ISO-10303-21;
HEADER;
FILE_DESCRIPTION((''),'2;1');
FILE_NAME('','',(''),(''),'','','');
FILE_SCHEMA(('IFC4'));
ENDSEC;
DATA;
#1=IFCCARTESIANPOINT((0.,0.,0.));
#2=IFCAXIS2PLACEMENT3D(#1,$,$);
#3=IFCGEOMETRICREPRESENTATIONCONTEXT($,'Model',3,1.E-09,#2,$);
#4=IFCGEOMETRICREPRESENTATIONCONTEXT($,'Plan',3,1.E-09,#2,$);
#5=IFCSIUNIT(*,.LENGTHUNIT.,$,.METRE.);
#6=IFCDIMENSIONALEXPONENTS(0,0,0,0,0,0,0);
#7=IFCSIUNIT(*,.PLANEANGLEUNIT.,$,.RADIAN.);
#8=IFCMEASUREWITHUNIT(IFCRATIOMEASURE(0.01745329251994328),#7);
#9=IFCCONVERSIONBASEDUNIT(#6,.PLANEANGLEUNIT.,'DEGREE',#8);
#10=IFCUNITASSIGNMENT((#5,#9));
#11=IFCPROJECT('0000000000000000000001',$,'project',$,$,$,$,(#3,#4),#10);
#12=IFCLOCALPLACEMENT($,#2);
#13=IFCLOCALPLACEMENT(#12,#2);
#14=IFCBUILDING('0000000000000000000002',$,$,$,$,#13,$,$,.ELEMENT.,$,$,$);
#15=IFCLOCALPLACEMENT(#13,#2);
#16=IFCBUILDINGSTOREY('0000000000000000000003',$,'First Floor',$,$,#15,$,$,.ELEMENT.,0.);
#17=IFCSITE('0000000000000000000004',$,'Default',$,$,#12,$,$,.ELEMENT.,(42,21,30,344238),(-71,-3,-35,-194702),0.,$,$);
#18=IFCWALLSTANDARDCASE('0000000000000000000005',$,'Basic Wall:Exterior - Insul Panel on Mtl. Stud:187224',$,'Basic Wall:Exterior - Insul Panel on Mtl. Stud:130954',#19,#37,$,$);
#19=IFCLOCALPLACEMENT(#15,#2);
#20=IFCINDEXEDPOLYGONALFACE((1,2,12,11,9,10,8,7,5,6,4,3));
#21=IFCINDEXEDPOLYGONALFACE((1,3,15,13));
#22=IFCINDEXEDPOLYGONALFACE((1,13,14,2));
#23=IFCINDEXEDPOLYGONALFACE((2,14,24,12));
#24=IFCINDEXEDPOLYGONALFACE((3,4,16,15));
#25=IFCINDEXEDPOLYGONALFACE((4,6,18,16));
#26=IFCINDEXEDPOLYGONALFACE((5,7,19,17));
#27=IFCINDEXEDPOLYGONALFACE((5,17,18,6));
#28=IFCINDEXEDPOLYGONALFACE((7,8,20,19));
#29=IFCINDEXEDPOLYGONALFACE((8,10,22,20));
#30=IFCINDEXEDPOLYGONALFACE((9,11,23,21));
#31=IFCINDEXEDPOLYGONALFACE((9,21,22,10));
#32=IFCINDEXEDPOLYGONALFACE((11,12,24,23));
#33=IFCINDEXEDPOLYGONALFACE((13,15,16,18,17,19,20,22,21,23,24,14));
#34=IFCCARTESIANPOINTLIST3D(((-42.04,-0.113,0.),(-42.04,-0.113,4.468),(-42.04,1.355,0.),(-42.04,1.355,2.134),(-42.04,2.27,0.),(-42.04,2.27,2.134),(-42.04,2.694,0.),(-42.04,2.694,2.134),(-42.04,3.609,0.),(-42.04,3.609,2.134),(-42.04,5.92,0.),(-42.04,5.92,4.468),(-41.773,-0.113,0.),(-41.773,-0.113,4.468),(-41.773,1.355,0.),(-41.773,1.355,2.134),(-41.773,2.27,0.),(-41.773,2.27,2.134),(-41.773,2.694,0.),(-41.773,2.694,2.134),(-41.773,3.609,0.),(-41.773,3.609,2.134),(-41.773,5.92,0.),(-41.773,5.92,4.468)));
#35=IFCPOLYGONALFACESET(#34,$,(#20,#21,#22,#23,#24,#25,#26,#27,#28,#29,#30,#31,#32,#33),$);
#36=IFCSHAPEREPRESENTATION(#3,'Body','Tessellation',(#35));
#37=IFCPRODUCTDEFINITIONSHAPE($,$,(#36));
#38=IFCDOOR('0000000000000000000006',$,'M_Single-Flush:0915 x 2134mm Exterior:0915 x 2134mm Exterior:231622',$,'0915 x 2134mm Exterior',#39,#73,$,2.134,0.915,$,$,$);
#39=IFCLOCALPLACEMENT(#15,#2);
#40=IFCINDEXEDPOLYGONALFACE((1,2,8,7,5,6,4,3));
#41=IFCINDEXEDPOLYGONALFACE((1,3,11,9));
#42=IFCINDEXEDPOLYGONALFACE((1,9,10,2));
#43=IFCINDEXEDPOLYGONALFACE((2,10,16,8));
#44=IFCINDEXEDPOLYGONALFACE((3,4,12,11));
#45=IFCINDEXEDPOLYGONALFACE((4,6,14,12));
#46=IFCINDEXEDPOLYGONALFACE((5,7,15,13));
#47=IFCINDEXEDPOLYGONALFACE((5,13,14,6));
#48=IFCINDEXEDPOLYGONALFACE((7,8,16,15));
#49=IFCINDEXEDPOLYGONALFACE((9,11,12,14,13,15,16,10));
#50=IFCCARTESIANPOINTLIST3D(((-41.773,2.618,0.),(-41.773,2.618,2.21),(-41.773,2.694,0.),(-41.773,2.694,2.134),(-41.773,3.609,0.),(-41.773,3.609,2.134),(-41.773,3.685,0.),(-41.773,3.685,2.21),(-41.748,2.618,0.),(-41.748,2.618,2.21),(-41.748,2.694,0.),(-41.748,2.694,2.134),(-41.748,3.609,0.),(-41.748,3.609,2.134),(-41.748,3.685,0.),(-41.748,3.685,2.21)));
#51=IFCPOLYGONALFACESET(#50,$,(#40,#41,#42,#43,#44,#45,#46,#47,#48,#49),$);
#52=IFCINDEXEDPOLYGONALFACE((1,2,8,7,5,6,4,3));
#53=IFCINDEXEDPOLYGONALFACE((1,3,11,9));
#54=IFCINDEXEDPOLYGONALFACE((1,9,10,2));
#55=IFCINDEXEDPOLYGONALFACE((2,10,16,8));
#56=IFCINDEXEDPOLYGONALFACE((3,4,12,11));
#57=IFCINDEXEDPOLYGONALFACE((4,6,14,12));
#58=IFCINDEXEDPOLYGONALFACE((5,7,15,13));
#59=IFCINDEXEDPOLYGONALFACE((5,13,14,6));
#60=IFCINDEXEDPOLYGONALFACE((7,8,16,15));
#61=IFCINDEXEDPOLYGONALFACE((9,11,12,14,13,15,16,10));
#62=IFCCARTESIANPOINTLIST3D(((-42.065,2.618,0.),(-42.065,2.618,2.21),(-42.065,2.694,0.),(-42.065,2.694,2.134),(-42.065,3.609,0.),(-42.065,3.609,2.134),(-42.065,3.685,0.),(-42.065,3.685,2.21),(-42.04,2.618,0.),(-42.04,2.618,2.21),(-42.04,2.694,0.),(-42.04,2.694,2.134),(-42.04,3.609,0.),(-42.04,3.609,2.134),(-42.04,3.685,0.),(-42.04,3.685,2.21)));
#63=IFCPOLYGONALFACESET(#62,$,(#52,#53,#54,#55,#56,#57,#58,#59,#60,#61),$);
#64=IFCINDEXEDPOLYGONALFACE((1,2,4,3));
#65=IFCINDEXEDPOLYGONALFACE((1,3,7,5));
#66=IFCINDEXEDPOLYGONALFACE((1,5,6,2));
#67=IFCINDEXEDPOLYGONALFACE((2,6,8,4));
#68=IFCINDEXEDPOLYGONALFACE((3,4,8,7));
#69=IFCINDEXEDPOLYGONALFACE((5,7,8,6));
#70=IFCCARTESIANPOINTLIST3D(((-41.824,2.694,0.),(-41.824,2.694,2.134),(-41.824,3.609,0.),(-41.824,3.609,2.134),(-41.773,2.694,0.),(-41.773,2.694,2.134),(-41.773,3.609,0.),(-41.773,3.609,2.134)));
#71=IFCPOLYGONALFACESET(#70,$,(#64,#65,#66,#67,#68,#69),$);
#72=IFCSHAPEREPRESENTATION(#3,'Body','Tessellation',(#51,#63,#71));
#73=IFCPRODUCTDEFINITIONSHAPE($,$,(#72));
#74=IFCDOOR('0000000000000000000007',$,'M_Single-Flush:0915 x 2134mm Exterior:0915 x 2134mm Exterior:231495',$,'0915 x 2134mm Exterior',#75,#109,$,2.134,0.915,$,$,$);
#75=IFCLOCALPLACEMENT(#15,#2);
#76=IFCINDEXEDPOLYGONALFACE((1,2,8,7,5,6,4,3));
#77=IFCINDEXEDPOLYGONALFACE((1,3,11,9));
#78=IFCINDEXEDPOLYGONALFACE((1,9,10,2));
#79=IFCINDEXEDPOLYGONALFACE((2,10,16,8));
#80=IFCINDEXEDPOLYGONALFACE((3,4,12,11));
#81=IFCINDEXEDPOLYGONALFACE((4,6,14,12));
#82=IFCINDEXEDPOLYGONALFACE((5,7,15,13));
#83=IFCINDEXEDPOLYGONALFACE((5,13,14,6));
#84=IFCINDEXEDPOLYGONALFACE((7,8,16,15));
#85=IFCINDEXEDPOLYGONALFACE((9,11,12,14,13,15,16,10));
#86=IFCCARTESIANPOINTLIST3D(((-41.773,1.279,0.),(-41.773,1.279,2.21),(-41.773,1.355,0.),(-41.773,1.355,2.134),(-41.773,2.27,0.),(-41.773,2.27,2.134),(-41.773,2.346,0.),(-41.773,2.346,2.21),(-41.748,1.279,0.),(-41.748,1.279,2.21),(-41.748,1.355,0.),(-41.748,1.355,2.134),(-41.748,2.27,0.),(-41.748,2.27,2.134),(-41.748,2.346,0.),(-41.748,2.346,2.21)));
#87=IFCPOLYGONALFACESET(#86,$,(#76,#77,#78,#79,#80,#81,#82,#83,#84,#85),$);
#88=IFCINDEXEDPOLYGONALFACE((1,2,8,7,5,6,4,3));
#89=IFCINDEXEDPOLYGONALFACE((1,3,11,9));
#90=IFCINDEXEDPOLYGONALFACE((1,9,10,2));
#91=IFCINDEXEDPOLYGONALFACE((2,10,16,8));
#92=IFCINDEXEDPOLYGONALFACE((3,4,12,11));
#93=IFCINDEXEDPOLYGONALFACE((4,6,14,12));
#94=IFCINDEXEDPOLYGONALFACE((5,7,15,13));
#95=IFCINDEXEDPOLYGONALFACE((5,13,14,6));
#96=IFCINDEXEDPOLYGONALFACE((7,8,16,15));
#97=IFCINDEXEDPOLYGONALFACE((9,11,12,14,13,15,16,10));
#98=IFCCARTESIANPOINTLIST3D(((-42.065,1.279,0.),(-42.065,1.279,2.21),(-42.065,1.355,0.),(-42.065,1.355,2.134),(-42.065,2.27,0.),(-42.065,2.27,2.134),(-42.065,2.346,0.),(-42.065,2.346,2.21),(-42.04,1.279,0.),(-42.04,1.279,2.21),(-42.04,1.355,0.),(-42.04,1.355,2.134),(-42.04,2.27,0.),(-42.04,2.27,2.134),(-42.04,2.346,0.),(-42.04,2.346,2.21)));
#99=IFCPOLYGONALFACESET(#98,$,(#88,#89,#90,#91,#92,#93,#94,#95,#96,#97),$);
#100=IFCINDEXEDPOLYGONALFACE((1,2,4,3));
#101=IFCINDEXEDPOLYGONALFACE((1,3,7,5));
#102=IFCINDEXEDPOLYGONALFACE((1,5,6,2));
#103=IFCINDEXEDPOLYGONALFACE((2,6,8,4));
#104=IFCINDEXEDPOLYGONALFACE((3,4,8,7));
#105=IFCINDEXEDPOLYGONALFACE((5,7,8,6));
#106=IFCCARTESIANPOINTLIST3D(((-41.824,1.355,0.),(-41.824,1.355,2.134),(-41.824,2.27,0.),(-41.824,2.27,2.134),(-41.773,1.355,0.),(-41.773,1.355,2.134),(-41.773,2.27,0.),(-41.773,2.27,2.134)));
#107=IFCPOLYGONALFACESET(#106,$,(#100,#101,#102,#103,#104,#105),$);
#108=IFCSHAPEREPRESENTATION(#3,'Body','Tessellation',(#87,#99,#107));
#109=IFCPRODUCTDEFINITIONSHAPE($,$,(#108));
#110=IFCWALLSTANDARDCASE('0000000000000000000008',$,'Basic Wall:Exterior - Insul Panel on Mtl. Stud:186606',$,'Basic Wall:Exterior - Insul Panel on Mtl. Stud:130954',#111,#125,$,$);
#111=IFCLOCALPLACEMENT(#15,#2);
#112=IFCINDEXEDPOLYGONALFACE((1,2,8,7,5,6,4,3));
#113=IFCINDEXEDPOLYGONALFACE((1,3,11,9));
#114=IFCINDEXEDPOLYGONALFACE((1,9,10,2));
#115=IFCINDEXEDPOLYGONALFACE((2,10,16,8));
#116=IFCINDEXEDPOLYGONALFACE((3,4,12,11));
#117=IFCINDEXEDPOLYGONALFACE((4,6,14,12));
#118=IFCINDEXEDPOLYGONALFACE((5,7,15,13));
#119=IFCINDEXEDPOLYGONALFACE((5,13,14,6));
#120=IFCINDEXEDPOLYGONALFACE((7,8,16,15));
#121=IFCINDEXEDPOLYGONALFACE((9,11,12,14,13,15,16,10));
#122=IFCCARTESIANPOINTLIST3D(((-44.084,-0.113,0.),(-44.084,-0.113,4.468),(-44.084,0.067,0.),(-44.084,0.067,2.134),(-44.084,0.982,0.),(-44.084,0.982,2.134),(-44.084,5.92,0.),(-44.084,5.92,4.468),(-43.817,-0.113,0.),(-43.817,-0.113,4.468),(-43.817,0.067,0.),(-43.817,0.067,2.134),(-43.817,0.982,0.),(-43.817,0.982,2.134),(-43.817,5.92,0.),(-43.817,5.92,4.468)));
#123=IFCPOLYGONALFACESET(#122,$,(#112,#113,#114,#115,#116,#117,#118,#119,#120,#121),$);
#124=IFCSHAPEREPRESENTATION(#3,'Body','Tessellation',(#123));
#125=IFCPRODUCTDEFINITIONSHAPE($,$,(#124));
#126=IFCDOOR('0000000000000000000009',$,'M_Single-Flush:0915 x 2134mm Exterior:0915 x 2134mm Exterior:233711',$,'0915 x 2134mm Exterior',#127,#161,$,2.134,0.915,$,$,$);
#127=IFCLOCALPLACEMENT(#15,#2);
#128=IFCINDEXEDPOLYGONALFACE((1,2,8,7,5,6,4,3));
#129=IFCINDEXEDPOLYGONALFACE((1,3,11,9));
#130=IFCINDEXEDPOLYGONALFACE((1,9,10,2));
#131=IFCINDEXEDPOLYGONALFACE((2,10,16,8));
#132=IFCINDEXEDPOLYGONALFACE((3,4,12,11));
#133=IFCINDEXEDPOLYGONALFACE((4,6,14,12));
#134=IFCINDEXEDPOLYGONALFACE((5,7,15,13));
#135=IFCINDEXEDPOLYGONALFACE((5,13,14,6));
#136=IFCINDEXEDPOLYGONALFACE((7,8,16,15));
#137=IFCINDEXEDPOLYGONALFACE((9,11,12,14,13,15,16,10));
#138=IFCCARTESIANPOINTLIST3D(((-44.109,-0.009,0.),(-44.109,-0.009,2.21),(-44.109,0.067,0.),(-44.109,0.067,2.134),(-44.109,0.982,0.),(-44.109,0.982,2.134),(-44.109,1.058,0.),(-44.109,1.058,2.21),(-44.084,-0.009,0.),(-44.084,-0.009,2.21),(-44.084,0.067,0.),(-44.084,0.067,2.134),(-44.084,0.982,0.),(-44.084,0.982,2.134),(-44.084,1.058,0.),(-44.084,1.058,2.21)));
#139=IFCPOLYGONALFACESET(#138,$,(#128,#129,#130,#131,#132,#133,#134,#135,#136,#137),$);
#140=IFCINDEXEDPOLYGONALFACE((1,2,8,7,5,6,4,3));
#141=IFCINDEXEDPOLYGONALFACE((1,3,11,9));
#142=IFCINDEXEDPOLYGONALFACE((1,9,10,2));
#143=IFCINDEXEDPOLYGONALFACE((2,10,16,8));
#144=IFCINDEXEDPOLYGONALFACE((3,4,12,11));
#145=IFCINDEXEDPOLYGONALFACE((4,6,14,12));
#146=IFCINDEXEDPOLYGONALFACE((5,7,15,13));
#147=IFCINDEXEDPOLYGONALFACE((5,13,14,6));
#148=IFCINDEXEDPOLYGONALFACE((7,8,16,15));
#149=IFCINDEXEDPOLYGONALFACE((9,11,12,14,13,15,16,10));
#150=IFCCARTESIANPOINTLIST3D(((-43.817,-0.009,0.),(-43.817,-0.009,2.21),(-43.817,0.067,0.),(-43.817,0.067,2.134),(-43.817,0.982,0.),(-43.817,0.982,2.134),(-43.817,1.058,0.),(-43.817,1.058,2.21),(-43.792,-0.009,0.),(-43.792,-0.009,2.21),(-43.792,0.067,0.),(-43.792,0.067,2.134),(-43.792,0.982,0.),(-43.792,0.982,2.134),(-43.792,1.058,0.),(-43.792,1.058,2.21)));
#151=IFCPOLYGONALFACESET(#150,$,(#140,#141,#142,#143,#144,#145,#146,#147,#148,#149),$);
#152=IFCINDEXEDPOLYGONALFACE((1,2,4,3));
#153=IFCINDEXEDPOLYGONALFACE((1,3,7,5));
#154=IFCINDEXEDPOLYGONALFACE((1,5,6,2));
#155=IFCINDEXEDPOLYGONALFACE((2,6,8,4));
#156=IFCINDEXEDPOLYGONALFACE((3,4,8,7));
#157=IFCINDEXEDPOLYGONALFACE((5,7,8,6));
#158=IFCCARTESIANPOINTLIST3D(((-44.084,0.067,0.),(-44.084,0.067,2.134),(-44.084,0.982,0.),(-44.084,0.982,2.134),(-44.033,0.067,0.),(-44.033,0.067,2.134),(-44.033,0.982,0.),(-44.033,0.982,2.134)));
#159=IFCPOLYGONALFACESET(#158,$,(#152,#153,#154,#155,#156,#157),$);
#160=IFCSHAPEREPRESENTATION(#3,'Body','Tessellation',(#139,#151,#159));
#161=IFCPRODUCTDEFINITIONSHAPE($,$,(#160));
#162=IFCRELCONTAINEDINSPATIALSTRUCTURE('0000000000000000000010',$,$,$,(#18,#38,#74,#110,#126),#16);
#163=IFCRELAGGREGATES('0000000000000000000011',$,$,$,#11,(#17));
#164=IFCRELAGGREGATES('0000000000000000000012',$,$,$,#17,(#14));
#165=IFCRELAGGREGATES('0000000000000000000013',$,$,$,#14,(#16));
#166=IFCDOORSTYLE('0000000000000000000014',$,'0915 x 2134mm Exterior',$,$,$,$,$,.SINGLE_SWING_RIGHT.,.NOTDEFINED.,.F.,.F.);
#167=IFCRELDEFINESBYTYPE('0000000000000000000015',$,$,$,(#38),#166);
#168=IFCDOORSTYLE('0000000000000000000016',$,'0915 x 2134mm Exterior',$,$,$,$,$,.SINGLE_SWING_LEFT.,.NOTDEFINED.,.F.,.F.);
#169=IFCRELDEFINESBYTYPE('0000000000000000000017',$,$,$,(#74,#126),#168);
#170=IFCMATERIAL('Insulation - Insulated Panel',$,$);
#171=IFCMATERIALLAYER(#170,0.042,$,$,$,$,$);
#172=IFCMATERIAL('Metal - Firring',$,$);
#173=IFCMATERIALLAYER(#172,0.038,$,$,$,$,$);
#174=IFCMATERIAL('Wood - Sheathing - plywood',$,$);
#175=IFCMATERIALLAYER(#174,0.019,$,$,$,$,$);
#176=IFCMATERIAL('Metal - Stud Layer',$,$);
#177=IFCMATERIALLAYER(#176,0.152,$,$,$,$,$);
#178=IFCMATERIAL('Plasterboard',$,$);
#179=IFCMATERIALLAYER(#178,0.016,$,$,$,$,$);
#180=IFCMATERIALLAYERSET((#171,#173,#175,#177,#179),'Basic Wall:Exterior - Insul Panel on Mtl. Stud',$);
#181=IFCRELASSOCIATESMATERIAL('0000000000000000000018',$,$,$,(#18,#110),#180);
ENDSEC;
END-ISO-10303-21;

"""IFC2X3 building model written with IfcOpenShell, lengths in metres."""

from ifc_helpers import new_model, entity, si_unit, converted_unit, frame, frame_2d, origin, origin_2d_with_axis, place, context, project, spatial, polyline, rectangle, outline, extrude, source, transform, mapped, material, layer, layer_set, layer_usage, type_object, type_shapes, element, fill, save


model = new_model("IFC2X3")

# Units and contexts
model_context = context("Model", 3, precision=1e-09, world=origin())
plan_context = context("Plan", 3, precision=1e-09, world=origin())
ifc_project = project(units=[si_unit("LENGTHUNIT", "METRE"), converted_unit("PLANEANGLEUNIT", "DEGREE", entity("IfcRatioMeasure", 0.01745329251994328), si_unit("PLANEANGLEUNIT", "RADIAN"), dimensions=[0, 0, 0, 0, 0, 0, 0])], contexts=[model_context, plan_context])

# Site, building, storey
site_placement = place(None, origin())
site = spatial("IfcSite", under=ifc_project, at=site_placement, Name="Default", CompositionType="ELEMENT", RefLatitude=(42, 21, 30, 344238), RefLongitude=(-71, -3, -35, -194702), RefElevation=0.0)
building_placement = place(site_placement, origin())
building = spatial("IfcBuilding", under=site, at=building_placement, CompositionType="ELEMENT")
storey_placement = place(building_placement, origin())
storey = spatial("IfcBuildingStorey", under=building, at=storey_placement, Name="First Floor", CompositionType="ELEMENT", Elevation=0.0)

# Shared definitions
ifc_material_1 = material(Name="Plasterboard")
ifc_material_2 = material(Name="Metal - Stud Layer")

# Wall, openings, doors
ifc_material_3 = material(Name="Insulation - Insulated Panel")
ifc_layer_1 = layer(ifc_material_3, 0.042)
ifc_material_4 = material(Name="Metal - Firring")
ifc_layer_2 = layer(ifc_material_4, 0.038)
ifc_material_5 = material(Name="Wood - Sheathing - plywood")
ifc_layer_3 = layer(ifc_material_5, 0.019)
ifc_layer_4 = layer(ifc_material_2, 0.152)
ifc_layer_5 = layer(ifc_material_1, 0.016)
ifc_layer_set_1 = layer_set([ifc_layer_1, ifc_layer_2, ifc_layer_3, ifc_layer_4, ifc_layer_5], Name="Basic Wall:Exterior - Insul Panel on Mtl. Stud")
ifc_layer_usage_1 = layer_usage(ifc_layer_set_1, "AXIS2", "NEGATIVE", 0.1335)
wall_1_placement = place(storey_placement, frame((-41.9065, -0.113, 0.0), z_axis=(0.0, 0.0, 1.0), x_axis=(0.0, 1.0, 0.0)))
wall_1 = element("IfcWallStandardCase", 1, at=wall_1_placement, inside=storey, material=ifc_layer_usage_1, Name="Basic Wall:Exterior - Insul Panel on Mtl. Stud:187224", ObjectType="Basic Wall:Exterior - Insul Panel on Mtl. Stud:130954", context=model_context, shape_type="SweptSolid", body=[
    extrude(rectangle(XDim=6.033, YDim=0.267, at=frame_2d((3.0165, 0.0), x_axis=(-1.0, 0.0))), origin(), (0.0, 0.0, 1.0), 4.468),
])
opening_1_placement = place(wall_1_placement, frame((2.383, 0.1335, 0.0)))
opening_1 = element("IfcOpeningElement", 2, at=opening_1_placement, cuts=wall_1, ObjectType="Opening", context=model_context, shape_type="SweptSolid", body=[
    extrude(rectangle(XDim=0.915, YDim=2.134, at=frame_2d((1.067, 0.4575), x_axis=(0.0, -1.0))), frame((0.0, 0.0, 0.0), z_axis=(0.0, -1.0, 0.0), x_axis=(0.0, 0.0, 1.0)), (0.0, 0.0, 1.0), 0.267),
])
opening_2_placement = place(wall_1_placement, frame((3.722, 0.1335, 0.0)))
opening_2 = element("IfcOpeningElement", 3, at=opening_2_placement, cuts=wall_1, ObjectType="Opening", context=model_context, shape_type="SweptSolid", body=[
    extrude(rectangle(XDim=0.915, YDim=2.134, at=frame_2d((1.067, 0.4575), x_axis=(0.0, 1.0))), frame((0.0, 0.0, 0.0), z_axis=(0.0, -1.0, 0.0), x_axis=(0.0, 0.0, 1.0)), (0.0, 0.0, 1.0), 0.267),
])
door_style_1 = type_object("IfcDoorStyle", Name="0915 x 2134mm Exterior", ConstructionType="NOTDEFINED", OperationType="SINGLE_SWING_RIGHT", ParameterTakesPrecedence=False, Sizeable=False)
shared_shape_1 = source(origin(), model_context, "Body", "SweptSolid", [
    extrude(outline(polyline([(-0.5335, -1.124), (0.5335, -1.124), (0.5335, 1.086), (0.4575, 1.086), (0.4575, -1.048), (-0.4575, -1.048), (-0.4575, 1.086), (-0.5335, 1.086), (-0.5335, -1.124)])), frame((0.4575, 0.267, 1.086), z_axis=(0.0, 1.0, 0.0), x_axis=(1.0, 0.0, 0.0)), (0.0, 0.0, 1.0), 0.025),
    extrude(outline(polyline([(-1.124, -0.5335), (1.086, -0.5335), (1.086, -0.4575), (-1.048, -0.4575), (-1.048, 0.4575), (1.086, 0.4575), (1.086, 0.5335), (-1.124, 0.5335), (-1.124, -0.5335)])), frame((0.4575, -0.025, 1.086), z_axis=(0.0, 1.0, 0.0), x_axis=(0.0, 0.0, -1.0)), (0.0, 0.0, 1.0), 0.025),
    extrude(rectangle(XDim=0.051, YDim=0.915, at=origin_2d_with_axis()), frame((0.4575, 0.2415, 0.0), z_axis=(0.0, 0.0, 1.0), x_axis=(0.0, 1.0, 0.0)), (0.0, 0.0, 1.0), 2.134),
])
type_shapes(door_style_1, [shared_shape_1])
door_1_placement = place(opening_2_placement, frame((0.0, 0.0, 0.0), z_axis=(0.0, 0.0, 1.0), x_axis=(-1.0, 0.0, 0.0)))
door_1 = element("IfcDoor", 4, at=door_1_placement, inside=storey, type_object=door_style_1, Name="M_Single-Flush:0915 x 2134mm Exterior:0915 x 2134mm Exterior:231622", ObjectType="0915 x 2134mm Exterior", OverallHeight=2.134, OverallWidth=0.915, context=model_context, shape_type="MappedRepresentation", body=[
    mapped(shared_shape_1, transform((0.0, 0.0, 0.0), scale=1.0)),
])
fill(opening_2, door_1)
door_style_2 = type_object("IfcDoorStyle", Name="0915 x 2134mm Exterior", ConstructionType="NOTDEFINED", OperationType="SINGLE_SWING_LEFT", ParameterTakesPrecedence=False, Sizeable=False)
shared_shape_2 = source(origin(), model_context, "Body", "SweptSolid", [
    extrude(outline(polyline([(-0.5335, -1.124), (0.5335, -1.124), (0.5335, 1.086), (0.4575, 1.086), (0.4575, -1.048), (-0.4575, -1.048), (-0.4575, 1.086), (-0.5335, 1.086), (-0.5335, -1.124)])), frame((0.4575, 0.292, 1.086), z_axis=(0.0, -1.0, 0.0), x_axis=(-1.0, 0.0, 0.0)), (0.0, 0.0, 1.0), 0.025),
    extrude(outline(polyline([(-1.124, -0.5335), (1.086, -0.5335), (1.086, -0.4575), (-1.048, -0.4575), (-1.048, 0.4575), (1.086, 0.4575), (1.086, 0.5335), (-1.124, 0.5335), (-1.124, -0.5335)])), frame((0.4575, 0.0, 1.086), z_axis=(0.0, -1.0, 0.0), x_axis=(0.0, 0.0, -1.0)), (0.0, 0.0, 1.0), 0.025),
    extrude(rectangle(XDim=0.915, YDim=0.051, at=origin_2d_with_axis()), frame((0.4575, 0.2415, 0.0)), (0.0, 0.0, 1.0), 2.134),
])
type_shapes(door_style_2, [shared_shape_2])
door_2_placement = place(opening_1_placement, frame((0.0, 0.0, 0.0), z_axis=(0.0, 0.0, 1.0), x_axis=(-1.0, 0.0, 0.0)))
door_2 = element("IfcDoor", 5, at=door_2_placement, inside=storey, type_object=door_style_2, Name="M_Single-Flush:0915 x 2134mm Exterior:0915 x 2134mm Exterior:231495", ObjectType="0915 x 2134mm Exterior", OverallHeight=2.134, OverallWidth=0.915, context=model_context, shape_type="MappedRepresentation", body=[
    mapped(shared_shape_2, transform((0.0, 0.0, 0.0), scale=1.0)),
])
fill(opening_1, door_2)

# Wall, opening, door
wall_2_placement = place(storey_placement, frame((-43.9505, 5.92, 0.0), z_axis=(0.0, 0.0, 1.0), x_axis=(0.0, -1.0, 0.0)))
wall_2 = element("IfcWallStandardCase", 6, at=wall_2_placement, inside=storey, material=ifc_layer_usage_1, Name="Basic Wall:Exterior - Insul Panel on Mtl. Stud:186606", ObjectType="Basic Wall:Exterior - Insul Panel on Mtl. Stud:130954", context=model_context, shape_type="SweptSolid", body=[
    extrude(rectangle(XDim=6.033, YDim=0.267, at=frame_2d((3.0165, 0.0), x_axis=(-1.0, 0.0))), origin(), (0.0, 0.0, 1.0), 4.468),
])
opening_3_placement = place(wall_2_placement, frame((5.853, 0.1335, 0.0)))
opening_3 = element("IfcOpeningElement", 7, at=opening_3_placement, cuts=wall_2, ObjectType="Opening", context=model_context, shape_type="SweptSolid", body=[
    extrude(rectangle(XDim=0.915, YDim=2.134, at=frame_2d((1.067, 0.4575), x_axis=(0.0, -1.0))), frame((0.0, 0.0, 0.0), z_axis=(0.0, -1.0, 0.0), x_axis=(0.0, 0.0, 1.0)), (0.0, 0.0, 1.0), 0.267),
])
door_3_placement = place(opening_3_placement, frame((0.0, 0.0, 0.0), z_axis=(0.0, 0.0, 1.0), x_axis=(-1.0, 0.0, 0.0)))
door_3 = element("IfcDoor", 8, at=door_3_placement, inside=storey, type_object=door_style_2, Name="M_Single-Flush:0915 x 2134mm Exterior:0915 x 2134mm Exterior:233711", ObjectType="0915 x 2134mm Exterior", OverallHeight=2.134, OverallWidth=0.915, context=model_context, shape_type="MappedRepresentation", body=[
    mapped(shared_shape_2, transform((0.0, 0.0, 0.0), scale=1.0)),
])
fill(opening_3, door_3)

save(model, "model.ifc")
